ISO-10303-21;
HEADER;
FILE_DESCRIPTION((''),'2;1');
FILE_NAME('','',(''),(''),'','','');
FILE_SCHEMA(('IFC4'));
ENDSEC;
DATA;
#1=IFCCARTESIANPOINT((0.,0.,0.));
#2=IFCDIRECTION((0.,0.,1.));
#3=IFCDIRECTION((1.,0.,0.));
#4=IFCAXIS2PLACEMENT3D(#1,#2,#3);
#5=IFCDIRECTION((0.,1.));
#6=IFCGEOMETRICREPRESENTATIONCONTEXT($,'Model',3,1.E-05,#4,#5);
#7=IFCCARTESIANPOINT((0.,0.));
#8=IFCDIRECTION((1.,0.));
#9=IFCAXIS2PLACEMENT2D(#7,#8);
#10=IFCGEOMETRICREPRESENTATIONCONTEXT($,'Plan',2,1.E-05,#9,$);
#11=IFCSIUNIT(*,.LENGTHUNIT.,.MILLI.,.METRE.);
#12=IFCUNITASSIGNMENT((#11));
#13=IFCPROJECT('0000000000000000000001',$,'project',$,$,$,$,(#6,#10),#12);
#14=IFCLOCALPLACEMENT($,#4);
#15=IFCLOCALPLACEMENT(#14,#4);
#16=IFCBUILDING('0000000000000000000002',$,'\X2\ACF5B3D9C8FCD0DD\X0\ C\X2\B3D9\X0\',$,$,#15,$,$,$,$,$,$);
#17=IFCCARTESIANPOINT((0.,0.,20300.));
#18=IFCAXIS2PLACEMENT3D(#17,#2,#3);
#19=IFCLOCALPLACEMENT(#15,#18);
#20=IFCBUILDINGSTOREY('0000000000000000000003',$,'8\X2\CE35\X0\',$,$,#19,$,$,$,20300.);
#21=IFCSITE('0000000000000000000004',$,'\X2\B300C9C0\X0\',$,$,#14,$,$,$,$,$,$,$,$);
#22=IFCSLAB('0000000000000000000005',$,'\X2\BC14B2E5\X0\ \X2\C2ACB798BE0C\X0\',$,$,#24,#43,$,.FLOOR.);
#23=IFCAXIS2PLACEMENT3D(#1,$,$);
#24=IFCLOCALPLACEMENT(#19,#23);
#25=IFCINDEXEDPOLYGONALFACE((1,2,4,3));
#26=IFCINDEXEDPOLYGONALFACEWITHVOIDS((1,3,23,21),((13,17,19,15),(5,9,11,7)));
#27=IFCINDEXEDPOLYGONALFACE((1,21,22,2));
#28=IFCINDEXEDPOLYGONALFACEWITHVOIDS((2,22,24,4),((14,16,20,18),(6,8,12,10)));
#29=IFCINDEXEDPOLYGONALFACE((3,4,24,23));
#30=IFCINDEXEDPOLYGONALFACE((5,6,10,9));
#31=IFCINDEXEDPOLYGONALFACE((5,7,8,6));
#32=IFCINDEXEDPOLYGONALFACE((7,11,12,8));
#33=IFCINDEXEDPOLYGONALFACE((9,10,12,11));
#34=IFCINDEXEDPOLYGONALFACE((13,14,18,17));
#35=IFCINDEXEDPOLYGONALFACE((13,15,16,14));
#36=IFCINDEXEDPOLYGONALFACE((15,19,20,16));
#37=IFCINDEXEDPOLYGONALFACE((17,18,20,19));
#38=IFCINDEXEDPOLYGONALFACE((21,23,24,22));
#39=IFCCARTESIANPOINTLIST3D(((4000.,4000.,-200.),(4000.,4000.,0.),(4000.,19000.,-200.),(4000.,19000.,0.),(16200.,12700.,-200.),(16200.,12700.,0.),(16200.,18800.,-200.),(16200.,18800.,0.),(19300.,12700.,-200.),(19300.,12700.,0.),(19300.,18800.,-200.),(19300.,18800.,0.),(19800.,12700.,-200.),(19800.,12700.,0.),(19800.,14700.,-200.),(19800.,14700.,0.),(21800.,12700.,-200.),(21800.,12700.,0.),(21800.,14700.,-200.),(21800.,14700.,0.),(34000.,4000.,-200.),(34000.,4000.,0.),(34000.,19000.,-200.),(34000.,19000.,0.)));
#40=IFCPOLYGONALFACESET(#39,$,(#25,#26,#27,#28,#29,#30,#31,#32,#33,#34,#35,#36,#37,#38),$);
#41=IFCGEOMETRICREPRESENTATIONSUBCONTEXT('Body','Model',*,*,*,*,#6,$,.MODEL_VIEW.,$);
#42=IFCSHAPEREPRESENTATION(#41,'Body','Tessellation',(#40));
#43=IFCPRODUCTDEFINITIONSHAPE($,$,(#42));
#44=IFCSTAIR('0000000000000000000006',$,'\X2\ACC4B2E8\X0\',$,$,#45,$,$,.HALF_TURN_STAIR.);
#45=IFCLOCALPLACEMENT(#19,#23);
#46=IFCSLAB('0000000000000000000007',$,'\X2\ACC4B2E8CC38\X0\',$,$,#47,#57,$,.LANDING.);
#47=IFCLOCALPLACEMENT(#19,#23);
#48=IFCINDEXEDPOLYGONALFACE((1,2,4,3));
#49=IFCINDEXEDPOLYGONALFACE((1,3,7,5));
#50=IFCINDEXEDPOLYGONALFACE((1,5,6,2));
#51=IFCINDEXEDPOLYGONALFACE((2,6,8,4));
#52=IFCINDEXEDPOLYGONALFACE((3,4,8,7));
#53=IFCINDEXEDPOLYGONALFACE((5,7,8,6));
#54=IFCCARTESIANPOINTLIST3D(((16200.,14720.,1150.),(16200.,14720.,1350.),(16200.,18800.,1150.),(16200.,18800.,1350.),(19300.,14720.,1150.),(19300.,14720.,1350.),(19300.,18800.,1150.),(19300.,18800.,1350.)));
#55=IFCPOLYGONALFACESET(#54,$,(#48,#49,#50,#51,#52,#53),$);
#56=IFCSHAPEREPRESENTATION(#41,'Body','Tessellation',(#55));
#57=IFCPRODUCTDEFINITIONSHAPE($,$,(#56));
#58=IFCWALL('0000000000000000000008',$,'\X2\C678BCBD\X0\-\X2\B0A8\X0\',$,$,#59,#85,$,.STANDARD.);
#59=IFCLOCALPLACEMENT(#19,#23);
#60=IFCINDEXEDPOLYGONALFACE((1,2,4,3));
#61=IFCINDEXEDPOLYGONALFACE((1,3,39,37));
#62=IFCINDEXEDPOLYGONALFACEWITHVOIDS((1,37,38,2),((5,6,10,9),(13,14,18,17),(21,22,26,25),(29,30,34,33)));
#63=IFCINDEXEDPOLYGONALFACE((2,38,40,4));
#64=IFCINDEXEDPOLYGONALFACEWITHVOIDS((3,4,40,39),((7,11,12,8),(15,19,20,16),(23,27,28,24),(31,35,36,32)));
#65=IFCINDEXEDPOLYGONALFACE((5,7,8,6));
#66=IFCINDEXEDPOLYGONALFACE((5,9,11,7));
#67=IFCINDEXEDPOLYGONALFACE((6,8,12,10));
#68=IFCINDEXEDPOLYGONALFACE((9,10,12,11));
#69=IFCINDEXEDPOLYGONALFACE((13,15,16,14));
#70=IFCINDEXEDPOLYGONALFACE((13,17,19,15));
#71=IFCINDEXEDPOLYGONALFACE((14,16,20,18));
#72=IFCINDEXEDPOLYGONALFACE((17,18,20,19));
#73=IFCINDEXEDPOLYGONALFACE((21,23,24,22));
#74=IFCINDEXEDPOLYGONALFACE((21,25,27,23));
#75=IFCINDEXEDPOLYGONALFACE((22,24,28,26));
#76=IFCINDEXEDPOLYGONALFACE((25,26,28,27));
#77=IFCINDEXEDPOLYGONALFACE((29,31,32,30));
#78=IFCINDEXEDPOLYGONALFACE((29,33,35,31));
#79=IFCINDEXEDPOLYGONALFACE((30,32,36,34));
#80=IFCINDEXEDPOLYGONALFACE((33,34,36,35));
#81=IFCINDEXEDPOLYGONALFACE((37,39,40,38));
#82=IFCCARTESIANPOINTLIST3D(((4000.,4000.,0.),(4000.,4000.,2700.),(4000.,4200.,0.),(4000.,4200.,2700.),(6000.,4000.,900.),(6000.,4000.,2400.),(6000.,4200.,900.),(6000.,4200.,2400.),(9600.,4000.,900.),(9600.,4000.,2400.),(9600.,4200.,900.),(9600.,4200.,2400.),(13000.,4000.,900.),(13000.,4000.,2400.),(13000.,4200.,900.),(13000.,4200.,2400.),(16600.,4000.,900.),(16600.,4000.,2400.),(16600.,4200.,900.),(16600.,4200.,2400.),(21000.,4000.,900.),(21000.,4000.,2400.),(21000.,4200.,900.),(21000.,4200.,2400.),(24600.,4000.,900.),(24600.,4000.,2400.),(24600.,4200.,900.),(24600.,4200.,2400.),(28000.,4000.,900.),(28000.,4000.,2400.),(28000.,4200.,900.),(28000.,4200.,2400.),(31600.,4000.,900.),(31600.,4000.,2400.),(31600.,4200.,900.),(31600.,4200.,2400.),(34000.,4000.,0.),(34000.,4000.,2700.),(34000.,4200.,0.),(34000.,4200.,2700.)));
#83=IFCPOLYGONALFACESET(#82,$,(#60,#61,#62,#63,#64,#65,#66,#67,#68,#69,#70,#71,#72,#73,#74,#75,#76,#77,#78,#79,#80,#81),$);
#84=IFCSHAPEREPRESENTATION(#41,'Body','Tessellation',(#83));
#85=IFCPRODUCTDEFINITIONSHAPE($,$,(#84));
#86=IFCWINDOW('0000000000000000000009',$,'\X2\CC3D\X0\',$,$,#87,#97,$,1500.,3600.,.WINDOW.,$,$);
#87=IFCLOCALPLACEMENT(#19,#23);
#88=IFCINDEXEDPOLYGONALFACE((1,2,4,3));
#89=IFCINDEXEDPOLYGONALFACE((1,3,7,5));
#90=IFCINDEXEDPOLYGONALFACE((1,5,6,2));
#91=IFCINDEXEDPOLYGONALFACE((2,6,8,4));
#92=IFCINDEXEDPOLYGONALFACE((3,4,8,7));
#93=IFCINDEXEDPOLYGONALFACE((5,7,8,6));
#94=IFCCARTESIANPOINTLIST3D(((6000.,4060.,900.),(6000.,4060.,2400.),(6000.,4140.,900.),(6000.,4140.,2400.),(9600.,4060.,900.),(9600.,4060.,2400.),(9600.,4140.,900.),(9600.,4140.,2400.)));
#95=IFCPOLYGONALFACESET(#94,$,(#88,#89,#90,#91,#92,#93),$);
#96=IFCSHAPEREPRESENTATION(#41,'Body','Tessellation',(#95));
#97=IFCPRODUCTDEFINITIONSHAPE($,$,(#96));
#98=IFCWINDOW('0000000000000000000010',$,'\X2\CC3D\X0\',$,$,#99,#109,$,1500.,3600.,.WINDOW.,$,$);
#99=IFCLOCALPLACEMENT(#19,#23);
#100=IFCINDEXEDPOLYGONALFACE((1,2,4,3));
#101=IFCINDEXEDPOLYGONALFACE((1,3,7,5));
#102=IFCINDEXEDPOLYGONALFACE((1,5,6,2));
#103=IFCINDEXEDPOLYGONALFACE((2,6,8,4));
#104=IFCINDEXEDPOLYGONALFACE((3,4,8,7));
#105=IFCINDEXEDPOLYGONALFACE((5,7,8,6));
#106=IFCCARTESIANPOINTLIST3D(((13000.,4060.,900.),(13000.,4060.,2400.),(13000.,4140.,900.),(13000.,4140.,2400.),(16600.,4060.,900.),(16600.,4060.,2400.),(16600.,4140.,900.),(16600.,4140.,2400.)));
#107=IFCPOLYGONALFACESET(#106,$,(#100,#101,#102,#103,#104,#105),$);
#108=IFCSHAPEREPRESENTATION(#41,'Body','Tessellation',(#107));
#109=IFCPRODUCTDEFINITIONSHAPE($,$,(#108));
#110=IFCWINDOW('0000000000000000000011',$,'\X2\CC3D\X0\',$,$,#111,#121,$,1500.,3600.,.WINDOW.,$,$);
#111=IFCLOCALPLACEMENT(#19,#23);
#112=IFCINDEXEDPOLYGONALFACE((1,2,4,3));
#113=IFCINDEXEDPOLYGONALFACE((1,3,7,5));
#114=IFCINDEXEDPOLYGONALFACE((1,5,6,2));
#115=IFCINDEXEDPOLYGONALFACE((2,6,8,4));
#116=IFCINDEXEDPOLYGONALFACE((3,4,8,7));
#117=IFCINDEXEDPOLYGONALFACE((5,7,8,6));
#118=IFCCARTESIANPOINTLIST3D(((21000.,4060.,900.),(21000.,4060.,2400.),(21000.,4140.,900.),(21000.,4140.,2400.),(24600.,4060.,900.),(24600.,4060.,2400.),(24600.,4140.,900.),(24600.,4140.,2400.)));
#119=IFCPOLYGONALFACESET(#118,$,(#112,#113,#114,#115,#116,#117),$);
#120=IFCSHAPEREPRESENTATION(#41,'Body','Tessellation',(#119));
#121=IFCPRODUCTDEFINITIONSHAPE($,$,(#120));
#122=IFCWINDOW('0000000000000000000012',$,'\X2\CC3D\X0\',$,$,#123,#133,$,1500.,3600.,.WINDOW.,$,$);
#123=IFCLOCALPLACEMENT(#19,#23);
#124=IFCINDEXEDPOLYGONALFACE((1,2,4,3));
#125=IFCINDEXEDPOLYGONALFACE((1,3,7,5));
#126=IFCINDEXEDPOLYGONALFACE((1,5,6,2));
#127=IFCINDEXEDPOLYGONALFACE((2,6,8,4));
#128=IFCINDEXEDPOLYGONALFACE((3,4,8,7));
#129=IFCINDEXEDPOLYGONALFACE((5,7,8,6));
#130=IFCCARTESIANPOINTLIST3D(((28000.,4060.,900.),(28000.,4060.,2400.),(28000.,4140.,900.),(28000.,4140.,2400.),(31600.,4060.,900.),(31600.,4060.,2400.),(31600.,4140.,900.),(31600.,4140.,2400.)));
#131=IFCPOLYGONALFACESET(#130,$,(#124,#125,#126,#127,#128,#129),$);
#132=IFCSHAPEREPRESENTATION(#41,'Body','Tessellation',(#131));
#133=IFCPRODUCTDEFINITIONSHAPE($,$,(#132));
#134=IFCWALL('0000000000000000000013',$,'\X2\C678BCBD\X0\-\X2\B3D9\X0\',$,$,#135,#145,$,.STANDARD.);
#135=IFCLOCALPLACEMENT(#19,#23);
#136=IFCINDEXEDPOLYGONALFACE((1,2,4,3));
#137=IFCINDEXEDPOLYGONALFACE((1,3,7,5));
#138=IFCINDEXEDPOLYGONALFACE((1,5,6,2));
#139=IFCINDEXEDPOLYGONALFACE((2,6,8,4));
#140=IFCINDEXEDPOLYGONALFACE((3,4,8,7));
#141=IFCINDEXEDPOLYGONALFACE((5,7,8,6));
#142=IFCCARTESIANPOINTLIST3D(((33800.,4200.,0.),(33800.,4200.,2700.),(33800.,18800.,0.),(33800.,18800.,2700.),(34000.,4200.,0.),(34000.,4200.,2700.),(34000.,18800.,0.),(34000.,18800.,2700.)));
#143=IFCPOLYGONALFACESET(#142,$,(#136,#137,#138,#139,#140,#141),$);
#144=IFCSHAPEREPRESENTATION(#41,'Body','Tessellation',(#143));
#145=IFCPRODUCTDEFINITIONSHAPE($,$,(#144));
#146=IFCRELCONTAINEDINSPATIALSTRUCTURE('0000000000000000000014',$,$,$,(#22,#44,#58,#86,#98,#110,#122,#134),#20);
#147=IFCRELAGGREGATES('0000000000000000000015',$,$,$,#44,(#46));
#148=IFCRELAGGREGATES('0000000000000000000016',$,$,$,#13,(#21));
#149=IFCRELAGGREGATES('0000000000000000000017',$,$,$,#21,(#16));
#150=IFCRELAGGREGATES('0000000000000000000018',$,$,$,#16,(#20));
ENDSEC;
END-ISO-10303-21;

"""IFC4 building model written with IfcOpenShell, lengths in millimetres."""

from ifc_helpers import new_model, si_unit, direction, frame, origin_with_axes, origin_2d_with_axis, place, context, subcontext, project, spatial, polyline, outline, extrude, element, fill, aggregate, save


model = new_model("IFC4")

# Units and contexts
model_context = context("Model", 3, precision=1e-05, world=origin_with_axes(), true_north=direction((0.0, 1.0)))
plan_context = context("Plan", 2, precision=1e-05, world=origin_2d_with_axis())
body_context = subcontext(model_context, "Body", "Model", "MODEL_VIEW")
ifc_project = project(units=[si_unit("LENGTHUNIT", "METRE", prefix="MILLI")], contexts=[model_context, plan_context])

# Site, building, storey
site_placement = place(None, origin_with_axes())
site = spatial("IfcSite", under=ifc_project, at=site_placement, Name="대지")
building_placement = place(site_placement, origin_with_axes())
building = spatial("IfcBuilding", under=site, at=building_placement, Name="공동주택 C동")
storey_placement = place(building_placement, frame((0.0, 0.0, 20300.0), z_axis=(0.0, 0.0, 1.0), x_axis=(1.0, 0.0, 0.0)))
storey = spatial("IfcBuildingStorey", under=building, at=storey_placement, Name="8층", Elevation=20300.0)

# Slab
slab_1_placement = place(storey_placement, origin_with_axes())
element("IfcSlab", 1, at=slab_1_placement, inside=storey, Name="바닥 슬래브", PredefinedType="FLOOR", context=body_context, shape_type="SweptSolid", body=[
    extrude(outline(polyline([(4000.0, 4000.0), (34000.0, 4000.0), (34000.0, 19000.0), (4000.0, 19000.0), (4000.0, 4000.0)]), holes=[polyline([(16200.0, 12700.0), (19300.0, 12700.0), (19300.0, 18800.0), (16200.0, 18800.0), (16200.0, 12700.0)]), polyline([(19800.0, 12700.0), (21800.0, 12700.0), (21800.0, 14700.0), (19800.0, 14700.0), (19800.0, 12700.0)])]), frame((0.0, 0.0, -200.0), z_axis=(0.0, 0.0, 1.0), x_axis=(1.0, 0.0, 0.0)), (0.0, 0.0, 1.0), 200.0),
])

# Stair, slab
stair_placement = place(storey_placement, origin_with_axes())
stair = element("IfcStair", 2, at=stair_placement, inside=storey, Name="계단", PredefinedType="HALF_TURN_STAIR")
slab_2_placement = place(stair_placement, origin_with_axes())
slab_2 = element("IfcSlab", 3, at=slab_2_placement, Name="계단참", PredefinedType="LANDING", context=body_context, shape_type="SweptSolid", body=[
    extrude(outline(polyline([(16200.0, 14720.0), (19300.0, 14720.0), (19300.0, 18800.0), (16200.0, 18800.0), (16200.0, 14720.0)])), frame((0.0, 0.0, 1150.0), z_axis=(0.0, 0.0, 1.0), x_axis=(1.0, 0.0, 0.0)), (0.0, 0.0, 1.0), 200.0),
])

# Wall, openings, windows
wall_1_placement = place(storey_placement, origin_with_axes())
wall_1 = element("IfcWall", 4, at=wall_1_placement, inside=storey, Name="외벽-남", PredefinedType="STANDARD", context=body_context, shape_type="SweptSolid", body=[
    extrude(outline(polyline([(4000.0, 4200.0), (34000.0, 4200.0), (34000.0, 4000.0), (4000.0, 4000.0), (4000.0, 4200.0)])), origin_with_axes(), (0.0, 0.0, 1.0), 2700.0),
])
opening_1_placement = place(storey_placement, origin_with_axes())
opening_1 = element("IfcOpeningElement", 5, at=opening_1_placement, cuts=wall_1, PredefinedType="OPENING", context=body_context, shape_type="SweptSolid", body=[
    extrude(outline(polyline([(6000.0, 3950.0), (9600.0, 3950.0), (9600.0, 4250.0), (6000.0, 4250.0), (6000.0, 3950.0)])), frame((0.0, 0.0, 900.0), z_axis=(0.0, 0.0, 1.0), x_axis=(1.0, 0.0, 0.0)), (0.0, 0.0, 1.0), 1500.0),
])
opening_2_placement = place(storey_placement, origin_with_axes())
opening_2 = element("IfcOpeningElement", 6, at=opening_2_placement, cuts=wall_1, PredefinedType="OPENING", context=body_context, shape_type="SweptSolid", body=[
    extrude(outline(polyline([(13000.0, 3950.0), (16600.0, 3950.0), (16600.0, 4250.0), (13000.0, 4250.0), (13000.0, 3950.0)])), frame((0.0, 0.0, 900.0), z_axis=(0.0, 0.0, 1.0), x_axis=(1.0, 0.0, 0.0)), (0.0, 0.0, 1.0), 1500.0),
])
opening_3_placement = place(storey_placement, origin_with_axes())
opening_3 = element("IfcOpeningElement", 7, at=opening_3_placement, cuts=wall_1, PredefinedType="OPENING", context=body_context, shape_type="SweptSolid", body=[
    extrude(outline(polyline([(21000.0, 3950.0), (24600.0, 3950.0), (24600.0, 4250.0), (21000.0, 4250.0), (21000.0, 3950.0)])), frame((0.0, 0.0, 900.0), z_axis=(0.0, 0.0, 1.0), x_axis=(1.0, 0.0, 0.0)), (0.0, 0.0, 1.0), 1500.0),
])
opening_4_placement = place(storey_placement, origin_with_axes())
opening_4 = element("IfcOpeningElement", 8, at=opening_4_placement, cuts=wall_1, PredefinedType="OPENING", context=body_context, shape_type="SweptSolid", body=[
    extrude(outline(polyline([(28000.0, 3950.0), (31600.0, 3950.0), (31600.0, 4250.0), (28000.0, 4250.0), (28000.0, 3950.0)])), frame((0.0, 0.0, 900.0), z_axis=(0.0, 0.0, 1.0), x_axis=(1.0, 0.0, 0.0)), (0.0, 0.0, 1.0), 1500.0),
])
window_1_placement = place(storey_placement, origin_with_axes())
window_1 = element("IfcWindow", 9, at=window_1_placement, inside=storey, Name="창", OverallHeight=1500.0, OverallWidth=3600.0, PredefinedType="WINDOW", context=body_context, shape_type="SweptSolid", body=[
    extrude(outline(polyline([(6000.0, 4060.0), (9600.0, 4060.0), (9600.0, 4140.0), (6000.0, 4140.0), (6000.0, 4060.0)])), frame((0.0, 0.0, 900.0), z_axis=(0.0, 0.0, 1.0), x_axis=(1.0, 0.0, 0.0)), (0.0, 0.0, 1.0), 1500.0),
])
fill(opening_1, window_1)
window_2_placement = place(storey_placement, origin_with_axes())
window_2 = element("IfcWindow", 10, at=window_2_placement, inside=storey, Name="창", OverallHeight=1500.0, OverallWidth=3600.0, PredefinedType="WINDOW", context=body_context, shape_type="SweptSolid", body=[
    extrude(outline(polyline([(13000.0, 4060.0), (16600.0, 4060.0), (16600.0, 4140.0), (13000.0, 4140.0), (13000.0, 4060.0)])), frame((0.0, 0.0, 900.0), z_axis=(0.0, 0.0, 1.0), x_axis=(1.0, 0.0, 0.0)), (0.0, 0.0, 1.0), 1500.0),
])
fill(opening_2, window_2)
window_3_placement = place(storey_placement, origin_with_axes())
window_3 = element("IfcWindow", 11, at=window_3_placement, inside=storey, Name="창", OverallHeight=1500.0, OverallWidth=3600.0, PredefinedType="WINDOW", context=body_context, shape_type="SweptSolid", body=[
    extrude(outline(polyline([(21000.0, 4060.0), (24600.0, 4060.0), (24600.0, 4140.0), (21000.0, 4140.0), (21000.0, 4060.0)])), frame((0.0, 0.0, 900.0), z_axis=(0.0, 0.0, 1.0), x_axis=(1.0, 0.0, 0.0)), (0.0, 0.0, 1.0), 1500.0),
])
fill(opening_3, window_3)
window_4_placement = place(storey_placement, origin_with_axes())
window_4 = element("IfcWindow", 12, at=window_4_placement, inside=storey, Name="창", OverallHeight=1500.0, OverallWidth=3600.0, PredefinedType="WINDOW", context=body_context, shape_type="SweptSolid", body=[
    extrude(outline(polyline([(28000.0, 4060.0), (31600.0, 4060.0), (31600.0, 4140.0), (28000.0, 4140.0), (28000.0, 4060.0)])), frame((0.0, 0.0, 900.0), z_axis=(0.0, 0.0, 1.0), x_axis=(1.0, 0.0, 0.0)), (0.0, 0.0, 1.0), 1500.0),
])
fill(opening_4, window_4)

# Wall
wall_2_placement = place(storey_placement, origin_with_axes())
element("IfcWall", 13, at=wall_2_placement, inside=storey, Name="외벽-동", PredefinedType="STANDARD", context=body_context, shape_type="SweptSolid", body=[
    extrude(outline(polyline([(33800.0, 4200.0), (33800.0, 18800.0), (34000.0, 18800.0), (34000.0, 4200.0), (33800.0, 4200.0)])), origin_with_axes(), (0.0, 0.0, 1.0), 2700.0),
])

aggregate(stair, [slab_2])

save(model, "model.ifc")
